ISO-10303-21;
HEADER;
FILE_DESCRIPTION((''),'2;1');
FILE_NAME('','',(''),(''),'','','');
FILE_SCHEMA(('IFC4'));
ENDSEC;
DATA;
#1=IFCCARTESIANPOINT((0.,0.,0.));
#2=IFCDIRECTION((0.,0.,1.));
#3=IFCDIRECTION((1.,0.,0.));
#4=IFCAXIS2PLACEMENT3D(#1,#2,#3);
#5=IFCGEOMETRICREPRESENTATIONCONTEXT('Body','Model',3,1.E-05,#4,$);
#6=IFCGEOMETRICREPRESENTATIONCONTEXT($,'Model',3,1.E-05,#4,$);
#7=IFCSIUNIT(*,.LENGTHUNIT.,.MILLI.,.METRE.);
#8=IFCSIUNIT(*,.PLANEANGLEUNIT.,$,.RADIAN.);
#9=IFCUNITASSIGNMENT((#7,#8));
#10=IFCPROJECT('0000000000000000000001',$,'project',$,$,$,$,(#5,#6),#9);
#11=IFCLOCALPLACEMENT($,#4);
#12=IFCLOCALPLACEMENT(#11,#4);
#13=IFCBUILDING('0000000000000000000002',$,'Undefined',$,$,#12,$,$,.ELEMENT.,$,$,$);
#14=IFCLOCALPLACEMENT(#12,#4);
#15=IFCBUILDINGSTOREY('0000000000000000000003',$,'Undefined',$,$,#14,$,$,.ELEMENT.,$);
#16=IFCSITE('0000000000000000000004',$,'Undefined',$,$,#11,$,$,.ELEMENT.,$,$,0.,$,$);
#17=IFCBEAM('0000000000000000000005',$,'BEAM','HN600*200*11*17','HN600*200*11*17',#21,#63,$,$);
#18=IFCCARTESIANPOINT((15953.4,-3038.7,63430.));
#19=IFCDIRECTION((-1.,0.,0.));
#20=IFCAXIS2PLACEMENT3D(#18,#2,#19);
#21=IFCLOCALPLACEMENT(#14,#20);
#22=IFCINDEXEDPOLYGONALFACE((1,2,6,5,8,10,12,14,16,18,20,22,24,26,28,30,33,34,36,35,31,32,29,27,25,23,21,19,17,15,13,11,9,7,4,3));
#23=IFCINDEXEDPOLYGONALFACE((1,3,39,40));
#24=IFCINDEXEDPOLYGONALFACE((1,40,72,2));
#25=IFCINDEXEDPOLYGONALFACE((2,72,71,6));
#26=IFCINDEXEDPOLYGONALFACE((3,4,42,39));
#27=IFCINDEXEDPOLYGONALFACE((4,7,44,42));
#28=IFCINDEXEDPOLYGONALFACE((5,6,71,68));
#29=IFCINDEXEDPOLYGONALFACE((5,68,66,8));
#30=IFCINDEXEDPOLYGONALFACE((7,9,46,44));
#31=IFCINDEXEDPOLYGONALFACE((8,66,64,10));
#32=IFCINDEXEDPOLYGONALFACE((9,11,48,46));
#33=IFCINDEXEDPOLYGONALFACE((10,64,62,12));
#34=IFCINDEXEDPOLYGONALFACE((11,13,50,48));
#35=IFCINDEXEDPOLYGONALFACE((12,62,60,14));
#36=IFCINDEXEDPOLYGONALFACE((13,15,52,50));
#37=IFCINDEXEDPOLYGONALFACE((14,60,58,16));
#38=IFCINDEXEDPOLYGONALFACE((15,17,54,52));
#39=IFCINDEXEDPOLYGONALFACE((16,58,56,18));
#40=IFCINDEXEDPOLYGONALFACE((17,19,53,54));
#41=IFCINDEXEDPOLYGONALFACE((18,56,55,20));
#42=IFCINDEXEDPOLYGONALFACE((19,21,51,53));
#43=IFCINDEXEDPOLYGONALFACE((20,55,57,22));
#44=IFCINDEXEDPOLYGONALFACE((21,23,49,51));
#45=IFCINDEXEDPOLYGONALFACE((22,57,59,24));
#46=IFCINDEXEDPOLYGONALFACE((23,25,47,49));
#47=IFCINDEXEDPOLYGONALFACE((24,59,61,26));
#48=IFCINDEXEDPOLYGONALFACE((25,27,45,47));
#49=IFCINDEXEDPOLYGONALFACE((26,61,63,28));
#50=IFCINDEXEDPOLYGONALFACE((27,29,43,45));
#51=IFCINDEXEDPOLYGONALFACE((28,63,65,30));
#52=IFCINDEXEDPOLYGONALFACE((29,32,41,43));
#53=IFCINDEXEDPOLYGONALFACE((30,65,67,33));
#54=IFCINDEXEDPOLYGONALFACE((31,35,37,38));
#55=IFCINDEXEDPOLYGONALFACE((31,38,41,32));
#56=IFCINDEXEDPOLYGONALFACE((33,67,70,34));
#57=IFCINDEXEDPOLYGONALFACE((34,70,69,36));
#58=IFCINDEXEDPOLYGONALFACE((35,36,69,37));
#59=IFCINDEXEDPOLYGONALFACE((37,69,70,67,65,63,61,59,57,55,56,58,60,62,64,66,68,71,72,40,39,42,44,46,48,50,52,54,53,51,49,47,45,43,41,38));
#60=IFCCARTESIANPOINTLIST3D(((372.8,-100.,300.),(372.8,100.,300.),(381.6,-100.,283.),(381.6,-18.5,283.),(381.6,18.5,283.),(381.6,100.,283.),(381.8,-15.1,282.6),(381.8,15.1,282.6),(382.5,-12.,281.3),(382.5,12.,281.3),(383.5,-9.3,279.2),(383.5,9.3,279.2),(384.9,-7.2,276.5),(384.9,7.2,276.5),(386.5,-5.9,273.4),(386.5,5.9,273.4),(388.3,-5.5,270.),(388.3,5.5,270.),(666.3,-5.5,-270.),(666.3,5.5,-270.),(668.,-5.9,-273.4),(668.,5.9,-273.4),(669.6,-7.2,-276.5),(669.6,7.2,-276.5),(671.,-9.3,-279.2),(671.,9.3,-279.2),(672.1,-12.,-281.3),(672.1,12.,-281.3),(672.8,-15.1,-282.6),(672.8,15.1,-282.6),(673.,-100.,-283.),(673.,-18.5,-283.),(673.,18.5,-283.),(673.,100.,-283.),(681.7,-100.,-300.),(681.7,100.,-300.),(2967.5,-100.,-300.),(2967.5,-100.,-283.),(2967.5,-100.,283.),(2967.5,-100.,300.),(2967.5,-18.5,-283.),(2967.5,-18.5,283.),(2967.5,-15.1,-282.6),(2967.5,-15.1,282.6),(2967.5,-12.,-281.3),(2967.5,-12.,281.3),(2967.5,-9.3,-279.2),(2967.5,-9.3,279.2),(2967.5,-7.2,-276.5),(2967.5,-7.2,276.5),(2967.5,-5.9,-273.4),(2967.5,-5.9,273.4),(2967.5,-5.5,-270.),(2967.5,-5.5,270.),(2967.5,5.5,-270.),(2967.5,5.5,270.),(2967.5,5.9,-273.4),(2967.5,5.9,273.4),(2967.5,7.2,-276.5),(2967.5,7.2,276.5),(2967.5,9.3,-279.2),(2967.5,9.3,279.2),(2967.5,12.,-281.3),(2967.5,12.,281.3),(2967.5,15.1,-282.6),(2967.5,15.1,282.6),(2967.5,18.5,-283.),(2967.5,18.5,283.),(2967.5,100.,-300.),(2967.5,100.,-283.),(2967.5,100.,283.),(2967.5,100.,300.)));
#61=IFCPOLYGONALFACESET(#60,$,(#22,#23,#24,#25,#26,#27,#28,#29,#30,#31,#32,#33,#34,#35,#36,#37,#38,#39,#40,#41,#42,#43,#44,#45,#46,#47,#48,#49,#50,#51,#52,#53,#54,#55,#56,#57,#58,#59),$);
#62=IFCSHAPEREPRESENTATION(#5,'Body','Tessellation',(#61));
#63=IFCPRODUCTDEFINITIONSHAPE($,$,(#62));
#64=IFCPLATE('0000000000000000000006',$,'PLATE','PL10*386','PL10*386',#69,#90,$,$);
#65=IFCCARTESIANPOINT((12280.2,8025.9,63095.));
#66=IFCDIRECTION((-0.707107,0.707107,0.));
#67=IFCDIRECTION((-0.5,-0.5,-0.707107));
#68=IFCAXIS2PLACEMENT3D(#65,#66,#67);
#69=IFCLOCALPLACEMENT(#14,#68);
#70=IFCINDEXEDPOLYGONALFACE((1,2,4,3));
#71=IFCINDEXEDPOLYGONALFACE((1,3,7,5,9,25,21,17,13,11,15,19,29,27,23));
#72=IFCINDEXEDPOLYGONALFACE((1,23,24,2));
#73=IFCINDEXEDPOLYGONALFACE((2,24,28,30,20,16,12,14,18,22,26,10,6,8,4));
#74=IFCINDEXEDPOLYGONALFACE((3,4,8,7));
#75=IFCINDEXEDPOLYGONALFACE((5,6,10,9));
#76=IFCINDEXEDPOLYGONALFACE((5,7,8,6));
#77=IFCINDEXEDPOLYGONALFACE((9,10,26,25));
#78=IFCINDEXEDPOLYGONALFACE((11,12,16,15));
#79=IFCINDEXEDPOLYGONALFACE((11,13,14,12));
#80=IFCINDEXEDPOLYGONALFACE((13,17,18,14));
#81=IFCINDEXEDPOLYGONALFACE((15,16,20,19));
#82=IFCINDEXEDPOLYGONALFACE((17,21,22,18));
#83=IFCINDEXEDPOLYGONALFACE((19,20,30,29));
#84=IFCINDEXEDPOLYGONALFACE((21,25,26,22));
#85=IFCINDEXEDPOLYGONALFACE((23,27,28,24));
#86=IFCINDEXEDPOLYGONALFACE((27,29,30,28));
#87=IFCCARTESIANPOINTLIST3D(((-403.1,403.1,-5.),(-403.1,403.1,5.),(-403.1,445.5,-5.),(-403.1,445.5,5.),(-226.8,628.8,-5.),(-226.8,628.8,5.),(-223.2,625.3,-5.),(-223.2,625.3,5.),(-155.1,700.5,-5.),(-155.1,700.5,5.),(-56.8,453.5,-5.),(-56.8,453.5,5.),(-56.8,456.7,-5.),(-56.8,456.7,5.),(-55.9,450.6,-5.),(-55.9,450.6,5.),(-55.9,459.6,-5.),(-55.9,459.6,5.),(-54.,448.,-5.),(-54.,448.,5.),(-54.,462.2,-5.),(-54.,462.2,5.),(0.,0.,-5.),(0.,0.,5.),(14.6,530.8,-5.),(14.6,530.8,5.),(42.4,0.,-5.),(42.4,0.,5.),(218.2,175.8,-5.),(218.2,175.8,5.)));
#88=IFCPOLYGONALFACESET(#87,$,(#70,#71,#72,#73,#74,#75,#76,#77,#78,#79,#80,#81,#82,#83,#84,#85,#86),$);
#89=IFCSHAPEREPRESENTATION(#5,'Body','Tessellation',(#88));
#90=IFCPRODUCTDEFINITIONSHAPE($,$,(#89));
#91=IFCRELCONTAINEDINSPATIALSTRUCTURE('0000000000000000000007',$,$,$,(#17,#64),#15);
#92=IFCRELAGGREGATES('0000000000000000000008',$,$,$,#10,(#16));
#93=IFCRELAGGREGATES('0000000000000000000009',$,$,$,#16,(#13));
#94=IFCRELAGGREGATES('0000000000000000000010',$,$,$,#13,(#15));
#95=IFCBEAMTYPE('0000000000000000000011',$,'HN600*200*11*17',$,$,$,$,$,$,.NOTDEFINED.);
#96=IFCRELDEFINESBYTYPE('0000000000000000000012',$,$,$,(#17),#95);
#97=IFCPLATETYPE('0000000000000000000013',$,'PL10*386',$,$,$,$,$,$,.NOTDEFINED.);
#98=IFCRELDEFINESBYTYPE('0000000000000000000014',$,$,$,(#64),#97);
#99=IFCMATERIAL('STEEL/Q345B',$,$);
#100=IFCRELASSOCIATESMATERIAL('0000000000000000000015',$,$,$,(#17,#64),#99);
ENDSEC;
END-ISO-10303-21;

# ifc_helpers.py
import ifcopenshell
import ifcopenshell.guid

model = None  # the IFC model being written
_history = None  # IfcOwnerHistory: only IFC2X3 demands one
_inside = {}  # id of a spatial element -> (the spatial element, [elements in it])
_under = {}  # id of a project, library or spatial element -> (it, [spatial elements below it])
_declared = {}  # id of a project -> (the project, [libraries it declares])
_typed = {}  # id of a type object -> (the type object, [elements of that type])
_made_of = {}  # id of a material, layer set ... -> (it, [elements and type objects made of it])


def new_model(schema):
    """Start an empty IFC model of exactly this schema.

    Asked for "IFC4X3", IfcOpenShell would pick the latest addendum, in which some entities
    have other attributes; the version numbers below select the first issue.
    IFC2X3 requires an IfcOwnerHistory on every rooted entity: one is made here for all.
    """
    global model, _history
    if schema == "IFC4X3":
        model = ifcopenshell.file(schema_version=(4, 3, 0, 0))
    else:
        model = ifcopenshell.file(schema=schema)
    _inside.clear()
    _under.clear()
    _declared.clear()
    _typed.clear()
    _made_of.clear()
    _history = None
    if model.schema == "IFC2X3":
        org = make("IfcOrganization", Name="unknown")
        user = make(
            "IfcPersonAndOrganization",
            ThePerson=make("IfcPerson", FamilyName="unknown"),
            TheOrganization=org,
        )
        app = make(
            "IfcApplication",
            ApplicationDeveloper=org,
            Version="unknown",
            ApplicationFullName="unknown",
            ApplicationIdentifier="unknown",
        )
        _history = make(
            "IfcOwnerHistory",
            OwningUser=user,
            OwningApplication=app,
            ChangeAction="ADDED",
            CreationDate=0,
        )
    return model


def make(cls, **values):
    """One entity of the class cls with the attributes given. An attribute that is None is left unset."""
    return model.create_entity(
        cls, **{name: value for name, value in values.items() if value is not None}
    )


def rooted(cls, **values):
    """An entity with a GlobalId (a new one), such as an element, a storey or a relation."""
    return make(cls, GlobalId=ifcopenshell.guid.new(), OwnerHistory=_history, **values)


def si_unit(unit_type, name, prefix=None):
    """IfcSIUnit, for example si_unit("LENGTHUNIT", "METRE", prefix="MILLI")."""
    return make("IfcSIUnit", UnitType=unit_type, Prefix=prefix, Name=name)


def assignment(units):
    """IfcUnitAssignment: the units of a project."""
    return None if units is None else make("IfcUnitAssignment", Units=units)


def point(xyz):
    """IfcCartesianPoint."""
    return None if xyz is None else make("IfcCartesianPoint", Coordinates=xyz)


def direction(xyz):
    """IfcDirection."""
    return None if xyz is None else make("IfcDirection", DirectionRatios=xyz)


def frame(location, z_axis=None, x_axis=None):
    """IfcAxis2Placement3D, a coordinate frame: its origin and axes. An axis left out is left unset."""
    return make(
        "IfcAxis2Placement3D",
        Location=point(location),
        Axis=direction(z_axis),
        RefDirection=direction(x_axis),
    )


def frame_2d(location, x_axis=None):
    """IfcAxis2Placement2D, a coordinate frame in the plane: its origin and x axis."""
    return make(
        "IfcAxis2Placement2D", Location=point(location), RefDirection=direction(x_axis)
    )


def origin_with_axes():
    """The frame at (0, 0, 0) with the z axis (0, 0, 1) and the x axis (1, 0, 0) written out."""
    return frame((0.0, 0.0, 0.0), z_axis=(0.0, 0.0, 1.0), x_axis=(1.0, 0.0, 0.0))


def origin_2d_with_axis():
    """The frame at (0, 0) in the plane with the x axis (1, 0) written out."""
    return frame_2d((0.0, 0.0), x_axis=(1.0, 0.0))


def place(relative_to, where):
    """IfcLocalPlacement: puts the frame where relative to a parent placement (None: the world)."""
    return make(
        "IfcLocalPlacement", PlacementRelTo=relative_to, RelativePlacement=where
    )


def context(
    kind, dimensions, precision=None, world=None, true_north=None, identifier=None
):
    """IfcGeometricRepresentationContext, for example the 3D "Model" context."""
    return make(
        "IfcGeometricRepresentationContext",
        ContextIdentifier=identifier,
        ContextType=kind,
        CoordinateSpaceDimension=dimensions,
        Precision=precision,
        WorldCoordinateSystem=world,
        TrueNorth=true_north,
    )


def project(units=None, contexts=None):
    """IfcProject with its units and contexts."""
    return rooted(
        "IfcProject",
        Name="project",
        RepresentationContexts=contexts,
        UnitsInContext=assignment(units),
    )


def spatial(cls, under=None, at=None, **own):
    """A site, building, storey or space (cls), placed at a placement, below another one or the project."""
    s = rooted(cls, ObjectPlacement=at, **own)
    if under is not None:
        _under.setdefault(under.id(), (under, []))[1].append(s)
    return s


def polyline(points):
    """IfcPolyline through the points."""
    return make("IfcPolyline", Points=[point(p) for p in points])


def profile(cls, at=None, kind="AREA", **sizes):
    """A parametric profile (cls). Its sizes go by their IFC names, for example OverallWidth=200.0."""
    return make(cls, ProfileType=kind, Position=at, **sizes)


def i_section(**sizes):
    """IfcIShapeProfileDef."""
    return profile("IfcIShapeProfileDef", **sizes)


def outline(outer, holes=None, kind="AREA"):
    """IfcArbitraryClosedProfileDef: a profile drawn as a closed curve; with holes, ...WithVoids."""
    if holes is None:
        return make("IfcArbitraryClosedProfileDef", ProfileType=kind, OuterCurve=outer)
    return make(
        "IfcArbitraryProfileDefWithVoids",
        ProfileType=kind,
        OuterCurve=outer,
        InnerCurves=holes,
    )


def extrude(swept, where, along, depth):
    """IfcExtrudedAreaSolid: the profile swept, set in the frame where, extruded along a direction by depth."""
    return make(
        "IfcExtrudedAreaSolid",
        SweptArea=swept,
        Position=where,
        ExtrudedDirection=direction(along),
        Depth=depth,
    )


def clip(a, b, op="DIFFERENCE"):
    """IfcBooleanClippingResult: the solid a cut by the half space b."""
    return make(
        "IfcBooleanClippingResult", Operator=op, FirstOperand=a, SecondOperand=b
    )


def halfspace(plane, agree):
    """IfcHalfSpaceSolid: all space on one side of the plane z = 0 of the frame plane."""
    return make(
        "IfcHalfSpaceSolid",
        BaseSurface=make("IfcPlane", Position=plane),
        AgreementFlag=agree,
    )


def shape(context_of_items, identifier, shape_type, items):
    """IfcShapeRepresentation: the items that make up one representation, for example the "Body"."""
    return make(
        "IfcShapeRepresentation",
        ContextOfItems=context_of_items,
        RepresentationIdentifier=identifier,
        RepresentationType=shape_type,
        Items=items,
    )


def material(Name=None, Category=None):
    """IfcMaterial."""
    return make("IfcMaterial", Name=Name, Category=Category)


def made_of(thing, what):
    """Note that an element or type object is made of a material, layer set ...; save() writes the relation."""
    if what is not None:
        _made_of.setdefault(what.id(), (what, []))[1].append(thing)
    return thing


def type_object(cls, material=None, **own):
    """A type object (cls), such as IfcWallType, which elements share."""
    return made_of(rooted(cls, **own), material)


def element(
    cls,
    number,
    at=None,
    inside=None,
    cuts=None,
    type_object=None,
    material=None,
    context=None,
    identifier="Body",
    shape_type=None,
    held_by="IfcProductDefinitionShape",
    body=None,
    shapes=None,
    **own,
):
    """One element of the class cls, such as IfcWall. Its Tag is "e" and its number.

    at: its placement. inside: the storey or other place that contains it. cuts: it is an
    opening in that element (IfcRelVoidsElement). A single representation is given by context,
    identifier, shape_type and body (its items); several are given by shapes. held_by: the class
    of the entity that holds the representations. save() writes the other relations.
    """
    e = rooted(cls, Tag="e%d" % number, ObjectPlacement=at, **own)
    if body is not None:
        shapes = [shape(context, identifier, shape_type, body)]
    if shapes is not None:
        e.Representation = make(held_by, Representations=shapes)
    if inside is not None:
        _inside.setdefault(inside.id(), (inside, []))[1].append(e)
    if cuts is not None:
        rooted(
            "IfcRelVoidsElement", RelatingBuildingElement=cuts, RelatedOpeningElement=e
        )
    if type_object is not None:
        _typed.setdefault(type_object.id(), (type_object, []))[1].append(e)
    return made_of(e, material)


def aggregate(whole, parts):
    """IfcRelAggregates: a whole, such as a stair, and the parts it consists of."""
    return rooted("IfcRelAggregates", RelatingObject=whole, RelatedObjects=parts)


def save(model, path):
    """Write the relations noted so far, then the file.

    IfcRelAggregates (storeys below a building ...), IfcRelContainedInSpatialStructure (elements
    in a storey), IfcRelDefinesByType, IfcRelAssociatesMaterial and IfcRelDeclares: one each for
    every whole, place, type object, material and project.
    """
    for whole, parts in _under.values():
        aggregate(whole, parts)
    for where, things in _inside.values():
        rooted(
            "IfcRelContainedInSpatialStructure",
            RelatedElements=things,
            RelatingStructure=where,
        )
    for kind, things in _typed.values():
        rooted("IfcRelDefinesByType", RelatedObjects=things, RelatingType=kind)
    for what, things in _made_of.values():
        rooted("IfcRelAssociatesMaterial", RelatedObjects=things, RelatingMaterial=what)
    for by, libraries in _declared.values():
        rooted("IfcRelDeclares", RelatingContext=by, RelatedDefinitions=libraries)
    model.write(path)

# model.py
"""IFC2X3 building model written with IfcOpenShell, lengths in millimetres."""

from ifc_helpers import new_model, si_unit, frame, origin_with_axes, origin_2d_with_axis, place, context, project, spatial, polyline, i_section, outline, extrude, clip, halfspace, material, type_object, element, save


model = new_model("IFC2X3")

# Units and contexts
model_context_1 = context("Model", 3, precision=1e-05, world=origin_with_axes(), identifier="Body")
model_context_2 = context("Model", 3, precision=1e-05, world=origin_with_axes())
ifc_project = project(units=[si_unit("LENGTHUNIT", "METRE", prefix="MILLI"), si_unit("PLANEANGLEUNIT", "RADIAN")], contexts=[model_context_1, model_context_2])

# Site, building, storey
site_placement = place(None, origin_with_axes())
site = spatial("IfcSite", under=ifc_project, at=site_placement, Name="Undefined", CompositionType="ELEMENT", RefElevation=0.0)
building_placement = place(site_placement, origin_with_axes())
building = spatial("IfcBuilding", under=site, at=building_placement, Name="Undefined", CompositionType="ELEMENT")
storey_placement = place(building_placement, origin_with_axes())
storey = spatial("IfcBuildingStorey", under=building, at=storey_placement, Name="Undefined", CompositionType="ELEMENT")

# Beam
ifc_material_1 = material(Name="STEEL/Q345B")
beam_type_1 = type_object("IfcBeamType", Name="HN600*200*11*17", PredefinedType="NOTDEFINED")
beam_1_placement = place(storey_placement, frame((15953.4, -3038.7, 63430.0), z_axis=(0.0, 0.0, 1.0), x_axis=(-1.0, 0.0, 0.0)))
element("IfcBeam", 1, at=beam_1_placement, inside=storey, type_object=beam_type_1, material=ifc_material_1, Name="BEAM", Description="HN600*200*11*17", ObjectType="HN600*200*11*17", context=model_context_1, shape_type="Clipping", body=[
    clip(clip(extrude(i_section(OverallWidth=200.0, OverallDepth=600.0, WebThickness=11.0, FlangeThickness=17.0, FilletRadius=13.0, at=origin_2d_with_axis()), frame((2967.5, 0.0, 0.0), z_axis=(-1.0, 0.0, 0.0), x_axis=(0.0, -1.0, 0.0)), (0.0, 0.0, 1.0), 2596.3), halfspace(frame((381.6, 0.0, 283.0), z_axis=(-0.88907, 0.0, -0.457771), x_axis=(0.0, -1.0, 0.0)), False)), halfspace(frame((2967.5, 0.0, -71.8), z_axis=(1.0, 0.0, 0.0), x_axis=(0.0, 0.0, 1.0)), False)),
])

# Plate
plate_type_1 = type_object("IfcPlateType", Name="PL10*386", PredefinedType="NOTDEFINED")
plate_1_placement = place(storey_placement, frame((12280.2, 8025.9, 63095.0), z_axis=(-0.707107, 0.707107, 0.0), x_axis=(-0.5, -0.5, -0.707107)))
element("IfcPlate", 2, at=plate_1_placement, inside=storey, type_object=plate_type_1, material=ifc_material_1, Name="PLATE", Description="PL10*386", ObjectType="PL10*386", context=model_context_1, shape_type="SweptSolid", body=[
    extrude(outline(polyline([(0.0, 0.0), (42.4, 0.0), (218.2, 175.8), (-54.0, 448.0), (-55.9, 450.6), (-56.8, 453.5), (-56.8, 456.7), (-55.9, 459.6), (-54.0, 462.2), (14.6, 530.8), (-155.1, 700.5), (-226.8, 628.8), (-223.2, 625.3), (-403.1, 445.5), (-403.1, 403.1), (0.0, 0.0)])), frame((0.0, 0.0, -5.0), z_axis=(0.0, 0.0, 1.0), x_axis=(1.0, 0.0, 0.0)), (0.0, 0.0, 1.0), 10.0),
])

save(model, "model.ifc")
